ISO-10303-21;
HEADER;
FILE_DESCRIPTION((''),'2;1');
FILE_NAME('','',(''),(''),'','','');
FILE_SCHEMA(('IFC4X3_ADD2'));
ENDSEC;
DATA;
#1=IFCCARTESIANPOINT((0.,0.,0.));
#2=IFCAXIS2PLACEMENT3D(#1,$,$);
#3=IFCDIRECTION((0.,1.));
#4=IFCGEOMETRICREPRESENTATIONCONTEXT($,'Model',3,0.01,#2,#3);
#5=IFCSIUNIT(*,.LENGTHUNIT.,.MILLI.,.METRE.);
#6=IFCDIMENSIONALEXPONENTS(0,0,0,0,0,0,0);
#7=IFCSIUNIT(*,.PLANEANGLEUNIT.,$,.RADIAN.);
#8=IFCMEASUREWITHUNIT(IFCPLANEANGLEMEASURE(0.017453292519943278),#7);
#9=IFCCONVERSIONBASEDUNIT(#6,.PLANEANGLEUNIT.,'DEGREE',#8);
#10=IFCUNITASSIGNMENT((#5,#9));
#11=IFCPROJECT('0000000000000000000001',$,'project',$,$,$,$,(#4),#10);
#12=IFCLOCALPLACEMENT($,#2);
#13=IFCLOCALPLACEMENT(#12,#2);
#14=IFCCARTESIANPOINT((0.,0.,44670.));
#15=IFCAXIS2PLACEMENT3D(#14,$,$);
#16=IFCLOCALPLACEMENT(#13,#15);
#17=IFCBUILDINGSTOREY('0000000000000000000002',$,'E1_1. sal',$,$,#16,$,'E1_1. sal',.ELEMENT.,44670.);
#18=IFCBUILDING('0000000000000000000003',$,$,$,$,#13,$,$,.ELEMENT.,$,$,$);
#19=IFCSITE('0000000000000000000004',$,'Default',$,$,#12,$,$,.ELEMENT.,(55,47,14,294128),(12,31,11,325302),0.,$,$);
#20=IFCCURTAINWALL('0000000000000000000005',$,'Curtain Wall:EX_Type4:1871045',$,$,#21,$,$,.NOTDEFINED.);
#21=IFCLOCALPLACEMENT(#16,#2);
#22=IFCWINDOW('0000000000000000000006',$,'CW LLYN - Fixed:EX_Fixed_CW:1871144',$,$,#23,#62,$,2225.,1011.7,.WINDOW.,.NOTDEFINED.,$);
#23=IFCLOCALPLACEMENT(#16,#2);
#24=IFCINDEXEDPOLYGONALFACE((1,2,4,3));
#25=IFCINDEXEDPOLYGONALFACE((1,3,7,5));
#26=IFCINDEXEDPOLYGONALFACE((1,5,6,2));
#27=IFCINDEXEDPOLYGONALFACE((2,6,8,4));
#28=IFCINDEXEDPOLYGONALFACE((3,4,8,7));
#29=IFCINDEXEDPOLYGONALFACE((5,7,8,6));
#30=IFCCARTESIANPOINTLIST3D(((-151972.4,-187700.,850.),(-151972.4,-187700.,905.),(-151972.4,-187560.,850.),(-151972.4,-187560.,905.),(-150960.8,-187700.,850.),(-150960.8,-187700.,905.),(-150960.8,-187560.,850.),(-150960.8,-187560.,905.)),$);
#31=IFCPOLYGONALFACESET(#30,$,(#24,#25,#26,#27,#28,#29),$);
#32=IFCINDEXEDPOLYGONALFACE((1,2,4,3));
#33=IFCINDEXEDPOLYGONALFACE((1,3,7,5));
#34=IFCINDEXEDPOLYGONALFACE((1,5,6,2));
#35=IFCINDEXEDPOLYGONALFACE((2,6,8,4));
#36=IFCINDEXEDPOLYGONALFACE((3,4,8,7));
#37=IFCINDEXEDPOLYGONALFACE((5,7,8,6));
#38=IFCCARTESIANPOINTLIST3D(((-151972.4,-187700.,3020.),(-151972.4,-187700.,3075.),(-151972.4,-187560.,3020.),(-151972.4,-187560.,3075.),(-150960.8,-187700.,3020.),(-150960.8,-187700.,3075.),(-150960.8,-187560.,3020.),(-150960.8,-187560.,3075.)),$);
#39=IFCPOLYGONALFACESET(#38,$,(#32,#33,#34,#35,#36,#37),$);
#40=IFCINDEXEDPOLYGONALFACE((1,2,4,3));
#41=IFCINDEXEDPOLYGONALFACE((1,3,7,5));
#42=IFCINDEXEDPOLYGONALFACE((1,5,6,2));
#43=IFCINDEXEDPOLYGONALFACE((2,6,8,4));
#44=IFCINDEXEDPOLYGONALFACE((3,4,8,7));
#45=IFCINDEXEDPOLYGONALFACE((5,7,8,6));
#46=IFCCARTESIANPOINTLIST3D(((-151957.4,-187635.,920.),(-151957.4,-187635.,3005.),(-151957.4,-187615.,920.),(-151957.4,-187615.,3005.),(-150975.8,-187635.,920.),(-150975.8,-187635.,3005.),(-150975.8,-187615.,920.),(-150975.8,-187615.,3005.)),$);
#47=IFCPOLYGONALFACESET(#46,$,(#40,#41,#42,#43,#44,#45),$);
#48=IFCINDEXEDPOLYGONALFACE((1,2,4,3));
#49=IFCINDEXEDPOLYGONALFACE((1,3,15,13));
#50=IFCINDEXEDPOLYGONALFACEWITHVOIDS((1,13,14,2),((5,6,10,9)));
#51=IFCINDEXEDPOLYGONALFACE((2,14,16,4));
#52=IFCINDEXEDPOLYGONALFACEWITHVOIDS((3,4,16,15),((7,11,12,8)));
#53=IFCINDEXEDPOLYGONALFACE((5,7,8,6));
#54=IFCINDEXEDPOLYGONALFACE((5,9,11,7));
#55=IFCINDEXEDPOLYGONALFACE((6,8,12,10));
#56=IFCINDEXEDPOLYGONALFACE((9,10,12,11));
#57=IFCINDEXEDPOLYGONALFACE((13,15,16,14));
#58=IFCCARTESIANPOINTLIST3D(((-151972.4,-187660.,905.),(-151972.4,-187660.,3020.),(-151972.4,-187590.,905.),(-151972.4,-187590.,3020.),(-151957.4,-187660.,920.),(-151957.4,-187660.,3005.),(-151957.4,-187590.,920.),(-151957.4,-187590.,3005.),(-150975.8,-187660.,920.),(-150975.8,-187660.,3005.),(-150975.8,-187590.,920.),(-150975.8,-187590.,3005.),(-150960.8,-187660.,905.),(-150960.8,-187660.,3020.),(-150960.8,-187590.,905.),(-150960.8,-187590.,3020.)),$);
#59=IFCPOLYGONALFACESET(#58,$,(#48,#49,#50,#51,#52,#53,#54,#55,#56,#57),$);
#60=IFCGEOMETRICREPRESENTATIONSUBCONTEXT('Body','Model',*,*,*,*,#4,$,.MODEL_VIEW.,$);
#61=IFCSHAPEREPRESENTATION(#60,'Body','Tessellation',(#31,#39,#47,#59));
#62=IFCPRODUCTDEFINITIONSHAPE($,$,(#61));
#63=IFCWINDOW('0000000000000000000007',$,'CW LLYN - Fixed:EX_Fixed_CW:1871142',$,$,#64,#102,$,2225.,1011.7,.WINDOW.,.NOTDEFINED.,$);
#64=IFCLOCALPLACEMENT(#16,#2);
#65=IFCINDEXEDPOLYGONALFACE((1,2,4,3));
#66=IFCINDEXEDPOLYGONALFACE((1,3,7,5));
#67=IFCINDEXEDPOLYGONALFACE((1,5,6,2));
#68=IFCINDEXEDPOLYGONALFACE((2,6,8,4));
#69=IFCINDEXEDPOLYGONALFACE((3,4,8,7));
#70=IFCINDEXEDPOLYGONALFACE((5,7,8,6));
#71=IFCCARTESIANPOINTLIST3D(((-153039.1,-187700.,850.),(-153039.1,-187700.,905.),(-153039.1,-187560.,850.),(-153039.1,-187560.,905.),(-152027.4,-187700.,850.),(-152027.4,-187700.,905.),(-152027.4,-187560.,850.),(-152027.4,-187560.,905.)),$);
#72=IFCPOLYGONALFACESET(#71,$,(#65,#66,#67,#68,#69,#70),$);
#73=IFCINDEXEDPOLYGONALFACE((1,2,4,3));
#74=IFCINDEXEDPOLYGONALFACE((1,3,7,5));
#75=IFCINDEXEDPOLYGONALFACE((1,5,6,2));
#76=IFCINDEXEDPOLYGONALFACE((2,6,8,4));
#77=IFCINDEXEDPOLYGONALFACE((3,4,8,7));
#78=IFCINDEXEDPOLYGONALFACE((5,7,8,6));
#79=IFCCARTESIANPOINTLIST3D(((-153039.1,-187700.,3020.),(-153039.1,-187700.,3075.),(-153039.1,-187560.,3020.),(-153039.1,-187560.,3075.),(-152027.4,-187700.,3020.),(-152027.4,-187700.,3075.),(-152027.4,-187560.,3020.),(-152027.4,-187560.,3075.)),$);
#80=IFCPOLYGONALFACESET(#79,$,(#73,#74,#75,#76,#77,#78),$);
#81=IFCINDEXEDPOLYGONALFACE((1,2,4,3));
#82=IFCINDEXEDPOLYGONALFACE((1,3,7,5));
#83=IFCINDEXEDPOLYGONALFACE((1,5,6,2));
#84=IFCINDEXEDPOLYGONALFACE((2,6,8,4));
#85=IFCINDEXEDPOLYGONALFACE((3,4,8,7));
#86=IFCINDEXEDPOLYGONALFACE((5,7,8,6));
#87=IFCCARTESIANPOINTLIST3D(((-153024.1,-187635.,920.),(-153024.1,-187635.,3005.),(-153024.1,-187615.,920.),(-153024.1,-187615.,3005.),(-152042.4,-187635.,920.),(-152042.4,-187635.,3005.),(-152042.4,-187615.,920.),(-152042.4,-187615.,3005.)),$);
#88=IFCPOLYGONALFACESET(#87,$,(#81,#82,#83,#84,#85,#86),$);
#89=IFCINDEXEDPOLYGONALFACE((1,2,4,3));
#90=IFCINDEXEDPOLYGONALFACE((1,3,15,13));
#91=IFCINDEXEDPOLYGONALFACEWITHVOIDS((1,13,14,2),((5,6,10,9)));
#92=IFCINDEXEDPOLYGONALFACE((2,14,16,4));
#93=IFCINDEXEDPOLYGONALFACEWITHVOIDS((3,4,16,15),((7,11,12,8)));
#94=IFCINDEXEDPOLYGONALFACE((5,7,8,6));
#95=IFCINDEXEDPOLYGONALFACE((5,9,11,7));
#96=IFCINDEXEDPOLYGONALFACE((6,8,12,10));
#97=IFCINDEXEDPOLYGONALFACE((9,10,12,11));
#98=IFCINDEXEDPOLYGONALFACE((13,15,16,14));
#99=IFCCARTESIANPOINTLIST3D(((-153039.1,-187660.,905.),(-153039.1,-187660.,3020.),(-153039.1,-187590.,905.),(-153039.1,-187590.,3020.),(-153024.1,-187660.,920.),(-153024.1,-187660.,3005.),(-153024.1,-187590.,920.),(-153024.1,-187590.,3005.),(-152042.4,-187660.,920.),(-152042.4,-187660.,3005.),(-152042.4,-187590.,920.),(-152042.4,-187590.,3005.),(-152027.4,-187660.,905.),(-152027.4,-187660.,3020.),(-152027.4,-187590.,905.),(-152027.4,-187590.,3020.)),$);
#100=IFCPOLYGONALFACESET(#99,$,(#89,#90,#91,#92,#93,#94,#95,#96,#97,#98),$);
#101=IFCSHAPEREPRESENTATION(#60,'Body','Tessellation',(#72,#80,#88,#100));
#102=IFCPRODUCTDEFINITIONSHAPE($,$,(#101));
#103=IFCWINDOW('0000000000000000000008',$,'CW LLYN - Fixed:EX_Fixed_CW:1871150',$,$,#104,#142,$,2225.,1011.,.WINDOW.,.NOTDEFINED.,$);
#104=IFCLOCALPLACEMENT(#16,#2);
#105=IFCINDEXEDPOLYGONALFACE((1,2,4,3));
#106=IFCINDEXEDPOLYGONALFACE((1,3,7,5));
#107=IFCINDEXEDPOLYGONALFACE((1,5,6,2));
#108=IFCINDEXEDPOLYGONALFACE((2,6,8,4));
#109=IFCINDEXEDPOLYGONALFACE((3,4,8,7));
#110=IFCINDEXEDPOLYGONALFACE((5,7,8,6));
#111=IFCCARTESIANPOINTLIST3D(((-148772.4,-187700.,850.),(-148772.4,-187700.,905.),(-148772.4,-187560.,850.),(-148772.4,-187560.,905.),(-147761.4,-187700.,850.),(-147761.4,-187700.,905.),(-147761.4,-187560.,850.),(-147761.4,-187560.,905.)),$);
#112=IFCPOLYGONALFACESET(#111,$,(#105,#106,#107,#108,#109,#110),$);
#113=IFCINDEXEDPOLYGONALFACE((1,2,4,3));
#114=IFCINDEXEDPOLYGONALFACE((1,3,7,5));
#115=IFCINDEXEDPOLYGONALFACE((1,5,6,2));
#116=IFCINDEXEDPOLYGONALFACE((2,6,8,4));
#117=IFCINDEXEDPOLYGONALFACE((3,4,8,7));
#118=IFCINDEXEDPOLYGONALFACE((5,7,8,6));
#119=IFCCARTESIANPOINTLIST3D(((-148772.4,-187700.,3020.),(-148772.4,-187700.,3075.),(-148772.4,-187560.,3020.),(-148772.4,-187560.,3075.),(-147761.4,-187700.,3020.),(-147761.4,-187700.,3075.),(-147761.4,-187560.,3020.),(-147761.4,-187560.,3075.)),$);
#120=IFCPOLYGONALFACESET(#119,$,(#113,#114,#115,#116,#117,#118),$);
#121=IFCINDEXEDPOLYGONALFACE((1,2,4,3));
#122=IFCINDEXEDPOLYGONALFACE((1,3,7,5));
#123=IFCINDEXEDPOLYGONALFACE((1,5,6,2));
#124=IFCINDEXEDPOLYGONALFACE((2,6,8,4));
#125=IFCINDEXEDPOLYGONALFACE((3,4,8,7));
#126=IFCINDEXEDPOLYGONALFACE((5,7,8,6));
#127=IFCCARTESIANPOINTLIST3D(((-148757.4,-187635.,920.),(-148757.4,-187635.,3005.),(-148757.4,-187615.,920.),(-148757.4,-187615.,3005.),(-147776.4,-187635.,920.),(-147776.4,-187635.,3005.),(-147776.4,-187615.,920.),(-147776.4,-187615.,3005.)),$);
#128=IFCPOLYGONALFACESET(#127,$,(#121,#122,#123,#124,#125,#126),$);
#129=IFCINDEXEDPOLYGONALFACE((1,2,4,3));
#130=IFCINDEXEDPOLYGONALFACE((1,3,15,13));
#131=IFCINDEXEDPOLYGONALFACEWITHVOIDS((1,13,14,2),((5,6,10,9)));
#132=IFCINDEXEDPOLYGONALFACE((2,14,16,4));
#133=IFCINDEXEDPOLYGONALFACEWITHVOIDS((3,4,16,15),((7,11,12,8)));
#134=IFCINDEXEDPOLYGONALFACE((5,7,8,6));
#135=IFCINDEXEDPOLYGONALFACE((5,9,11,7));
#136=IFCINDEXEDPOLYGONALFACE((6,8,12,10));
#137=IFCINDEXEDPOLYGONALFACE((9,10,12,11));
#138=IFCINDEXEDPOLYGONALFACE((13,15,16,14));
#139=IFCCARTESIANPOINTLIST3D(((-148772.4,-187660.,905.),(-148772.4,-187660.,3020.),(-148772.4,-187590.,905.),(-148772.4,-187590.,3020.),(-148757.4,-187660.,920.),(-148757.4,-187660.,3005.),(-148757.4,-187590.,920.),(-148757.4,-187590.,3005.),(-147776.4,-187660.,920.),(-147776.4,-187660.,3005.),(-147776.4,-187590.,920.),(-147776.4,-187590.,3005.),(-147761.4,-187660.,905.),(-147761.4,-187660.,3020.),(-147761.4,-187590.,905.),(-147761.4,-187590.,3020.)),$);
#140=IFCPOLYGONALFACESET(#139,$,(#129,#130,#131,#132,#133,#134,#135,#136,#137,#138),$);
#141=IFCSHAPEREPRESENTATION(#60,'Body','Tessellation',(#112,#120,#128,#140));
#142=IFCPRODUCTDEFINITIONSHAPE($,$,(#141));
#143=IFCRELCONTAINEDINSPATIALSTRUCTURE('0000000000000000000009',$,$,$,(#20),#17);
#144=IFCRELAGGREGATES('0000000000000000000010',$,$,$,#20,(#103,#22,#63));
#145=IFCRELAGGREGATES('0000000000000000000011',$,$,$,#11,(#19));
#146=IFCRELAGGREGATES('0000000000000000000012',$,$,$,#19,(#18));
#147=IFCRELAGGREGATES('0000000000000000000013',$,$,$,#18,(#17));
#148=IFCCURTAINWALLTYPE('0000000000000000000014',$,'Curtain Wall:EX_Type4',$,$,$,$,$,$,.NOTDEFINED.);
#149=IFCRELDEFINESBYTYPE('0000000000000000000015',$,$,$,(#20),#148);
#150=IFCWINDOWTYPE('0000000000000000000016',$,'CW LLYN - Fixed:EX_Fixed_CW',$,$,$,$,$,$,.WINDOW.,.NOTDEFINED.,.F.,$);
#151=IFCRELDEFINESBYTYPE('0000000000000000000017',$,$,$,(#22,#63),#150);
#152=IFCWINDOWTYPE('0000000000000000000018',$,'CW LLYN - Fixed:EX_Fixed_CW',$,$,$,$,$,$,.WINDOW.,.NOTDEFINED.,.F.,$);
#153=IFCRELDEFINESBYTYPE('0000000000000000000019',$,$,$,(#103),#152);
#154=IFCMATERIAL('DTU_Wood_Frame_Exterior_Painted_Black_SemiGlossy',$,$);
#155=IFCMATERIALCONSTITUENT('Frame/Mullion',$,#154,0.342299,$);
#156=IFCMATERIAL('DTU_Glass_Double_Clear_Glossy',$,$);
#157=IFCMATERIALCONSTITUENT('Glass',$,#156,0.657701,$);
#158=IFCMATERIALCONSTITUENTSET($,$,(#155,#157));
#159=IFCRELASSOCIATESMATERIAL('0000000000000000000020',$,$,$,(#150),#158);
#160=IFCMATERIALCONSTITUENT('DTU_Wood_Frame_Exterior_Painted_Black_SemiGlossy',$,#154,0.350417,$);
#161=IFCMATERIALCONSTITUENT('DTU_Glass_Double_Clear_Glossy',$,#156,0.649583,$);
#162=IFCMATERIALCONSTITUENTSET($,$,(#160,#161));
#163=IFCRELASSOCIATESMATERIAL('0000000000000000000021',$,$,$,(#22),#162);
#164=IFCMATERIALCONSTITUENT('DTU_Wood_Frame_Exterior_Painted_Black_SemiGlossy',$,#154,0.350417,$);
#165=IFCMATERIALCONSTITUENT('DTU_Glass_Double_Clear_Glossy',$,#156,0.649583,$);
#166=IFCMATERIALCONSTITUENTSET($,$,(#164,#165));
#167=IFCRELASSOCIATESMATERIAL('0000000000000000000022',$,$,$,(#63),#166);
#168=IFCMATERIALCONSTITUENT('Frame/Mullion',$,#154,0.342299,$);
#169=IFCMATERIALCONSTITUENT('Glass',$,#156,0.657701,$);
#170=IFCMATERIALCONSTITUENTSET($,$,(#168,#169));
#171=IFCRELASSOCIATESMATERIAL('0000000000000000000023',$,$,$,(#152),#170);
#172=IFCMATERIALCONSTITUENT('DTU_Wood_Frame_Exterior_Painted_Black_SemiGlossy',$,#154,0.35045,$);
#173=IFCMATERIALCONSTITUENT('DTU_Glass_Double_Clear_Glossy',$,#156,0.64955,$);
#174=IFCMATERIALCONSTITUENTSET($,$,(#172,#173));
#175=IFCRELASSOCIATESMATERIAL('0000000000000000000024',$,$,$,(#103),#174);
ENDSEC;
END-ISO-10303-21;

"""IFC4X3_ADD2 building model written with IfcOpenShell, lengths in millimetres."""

from ifc_helpers import new_model, entity, si_unit, converted_unit, direction, frame, frame_2d, origin, origin_2d_with_axis, place, context, subcontext, project, spatial, polyline, rectangle, outline, extrude, source, transform, mapped, material, constituent, constituent_set, type_object, type_shapes, element, aggregate, save


model = new_model("IFC4X3_ADD2")

# Units and contexts
model_context = context("Model", 3, precision=0.01, world=origin(), true_north=direction((0.0, 1.0)))
body_context = subcontext(model_context, "Body", "Model", "MODEL_VIEW")
ifc_project = project(units=[si_unit("LENGTHUNIT", "METRE", prefix="MILLI"), converted_unit("PLANEANGLEUNIT", "DEGREE", entity("IfcPlaneAngleMeasure", 0.017453292519943278), si_unit("PLANEANGLEUNIT", "RADIAN"), dimensions=[0, 0, 0, 0, 0, 0, 0])], contexts=[model_context])

# Site, building, storey
site_placement = place(None, origin())
site = spatial("IfcSite", under=ifc_project, at=site_placement, Name="Default", CompositionType="ELEMENT", RefLatitude=(55, 47, 14, 294128), RefLongitude=(12, 31, 11, 325302), RefElevation=0.0)
building_placement = place(site_placement, origin())
building = spatial("IfcBuilding", under=site, at=building_placement, CompositionType="ELEMENT")
storey_placement = place(building_placement, frame((0.0, 0.0, 44670.0)))
storey = spatial("IfcBuildingStorey", under=building, at=storey_placement, Name="E1_1. sal", LongName="E1_1. sal", CompositionType="ELEMENT", Elevation=44670.0)

# Curtain wall
curtain_wall_type = type_object("IfcCurtainWallType", Name="Curtain Wall:EX_Type4", PredefinedType="NOTDEFINED")
curtain_wall_placement = place(storey_placement, frame((0.0, 0.0, -44670.0)))
curtain_wall = element("IfcCurtainWall", 1, at=curtain_wall_placement, inside=storey, type_object=curtain_wall_type, Name="Curtain Wall:EX_Type4:1871045", PredefinedType="NOTDEFINED")

# Windows
ifc_material_1 = material(Name="DTU_Wood_Frame_Exterior_Painted_Black_SemiGlossy")
ifc_material_2 = material(Name="DTU_Glass_Double_Clear_Glossy")
ifc_constituent_1 = constituent(ifc_material_1, Name="Frame/Mullion", fraction=0.342299)
ifc_constituent_2 = constituent(ifc_material_2, Name="Glass", fraction=0.657701)
ifc_constituent_set_1 = constituent_set(constituents=[ifc_constituent_1, ifc_constituent_2])
window_type_1 = type_object("IfcWindowType", Name="CW LLYN - Fixed:EX_Fixed_CW", ParameterTakesPrecedence=False, PartitioningType="NOTDEFINED", PredefinedType="WINDOW", material=ifc_constituent_set_1)
shared_shape_1 = source(origin(), body_context, "Body", "SweptSolid", [
    extrude(rectangle(XDim=140.0, YDim=1011.7, at=origin_2d_with_axis()), frame((0.0, -130.0, 0.0), z_axis=(0.0, 0.0, 1.0), x_axis=(0.0, -1.0, 0.0)), (0.0, 0.0, 1.0), 55.0),
    extrude(rectangle(XDim=140.0, YDim=1011.7, at=frame_2d((0.0, 0.0), x_axis=(1.0, 0.0))), frame((0.0, -130.0, 2170.0), z_axis=(0.0, 0.0, 1.0), x_axis=(0.0, -1.0, 0.0)), (0.0, 0.0, 1.0), 55.0),
    extrude(rectangle(XDim=981.7, YDim=20.0, at=frame_2d((0.0, 0.0), x_axis=(1.0, 0.0))), frame((0.0, -125.0, 70.0), z_axis=(0.0, 0.0, 1.0), x_axis=(-1.0, 0.0, 0.0)), (0.0, 0.0, 1.0), 2085.0),
    extrude(outline(polyline([(-1057.5, -505.8), (1057.5, -505.8), (1057.5, 505.8), (-1057.5, 505.8), (-1057.5, -505.8)]), holes=[polyline([(-1042.5, 490.8), (1042.5, 490.8), (1042.5, -490.8), (-1042.5, -490.8), (-1042.5, 490.8)])]), frame((0.0, -90.0, 1112.5), z_axis=(0.0, -1.0, 0.0), x_axis=(0.0, 0.0, 1.0)), (0.0, 0.0, 1.0), 70.0),
])
type_shapes(window_type_1, [shared_shape_1])
ifc_constituent_3 = constituent(ifc_material_1, Name="DTU_Wood_Frame_Exterior_Painted_Black_SemiGlossy", fraction=0.350417)
ifc_constituent_4 = constituent(ifc_material_2, Name="DTU_Glass_Double_Clear_Glossy", fraction=0.649583)
ifc_constituent_set_2 = constituent_set(constituents=[ifc_constituent_3, ifc_constituent_4])
window_1_placement = place(curtain_wall_placement, frame((-151466.6, -187500.0, 45520.0)))
window_1 = element("IfcWindow", 2, at=window_1_placement, type_object=window_type_1, material=ifc_constituent_set_2, Name="CW LLYN - Fixed:EX_Fixed_CW:1871144", OverallHeight=2225.0, OverallWidth=1011.7, PartitioningType="NOTDEFINED", PredefinedType="WINDOW", context=body_context, shape_type="MappedRepresentation", body=[
    mapped(shared_shape_1, transform((0.0, 0.0, 0.0), scale=1.0)),
])
ifc_constituent_5 = constituent(ifc_material_1, Name="DTU_Wood_Frame_Exterior_Painted_Black_SemiGlossy", fraction=0.350417)
ifc_constituent_6 = constituent(ifc_material_2, Name="DTU_Glass_Double_Clear_Glossy", fraction=0.649583)
ifc_constituent_set_3 = constituent_set(constituents=[ifc_constituent_5, ifc_constituent_6])
window_2_placement = place(curtain_wall_placement, frame((-152533.3, -187500.0, 45520.0)))
window_2 = element("IfcWindow", 3, at=window_2_placement, type_object=window_type_1, material=ifc_constituent_set_3, Name="CW LLYN - Fixed:EX_Fixed_CW:1871142", OverallHeight=2225.0, OverallWidth=1011.7, PartitioningType="NOTDEFINED", PredefinedType="WINDOW", context=body_context, shape_type="MappedRepresentation", body=[
    mapped(shared_shape_1, transform((0.0, 0.0, 0.0), scale=1.0)),
])

# Window
ifc_constituent_7 = constituent(ifc_material_1, Name="DTU_Wood_Frame_Exterior_Painted_Black_SemiGlossy", fraction=0.35045)
ifc_constituent_8 = constituent(ifc_material_2, Name="DTU_Glass_Double_Clear_Glossy", fraction=0.64955)
ifc_constituent_set_4 = constituent_set(constituents=[ifc_constituent_7, ifc_constituent_8])
ifc_constituent_9 = constituent(ifc_material_1, Name="Frame/Mullion", fraction=0.342299)
ifc_constituent_10 = constituent(ifc_material_2, Name="Glass", fraction=0.657701)
ifc_constituent_set_5 = constituent_set(constituents=[ifc_constituent_9, ifc_constituent_10])
window_type_2 = type_object("IfcWindowType", Name="CW LLYN - Fixed:EX_Fixed_CW", ParameterTakesPrecedence=False, PartitioningType="NOTDEFINED", PredefinedType="WINDOW", material=ifc_constituent_set_5)
shared_shape_2 = source(origin(), body_context, "Body", "SweptSolid", [
    extrude(rectangle(XDim=140.0, YDim=1011.0, at=origin_2d_with_axis()), frame((0.0, -130.0, 0.0), z_axis=(0.0, 0.0, 1.0), x_axis=(0.0, -1.0, 0.0)), (0.0, 0.0, 1.0), 55.0),
    extrude(rectangle(XDim=140.0, YDim=1011.0, at=frame_2d((0.0, 0.0), x_axis=(1.0, 0.0))), frame((0.0, -130.0, 2170.0), z_axis=(0.0, 0.0, 1.0), x_axis=(0.0, -1.0, 0.0)), (0.0, 0.0, 1.0), 55.0),
    extrude(rectangle(XDim=981.0, YDim=20.0, at=origin_2d_with_axis()), frame((0.0, -125.0, 70.0), z_axis=(0.0, 0.0, 1.0), x_axis=(-1.0, 0.0, 0.0)), (0.0, 0.0, 1.0), 2085.0),
    extrude(outline(polyline([(-1057.5, -505.5), (1057.5, -505.5), (1057.5, 505.5), (-1057.5, 505.5), (-1057.5, -505.5)]), holes=[polyline([(-1042.5, 490.5), (1042.5, 490.5), (1042.5, -490.5), (-1042.5, -490.5), (-1042.5, 490.5)])]), frame((0.0, -90.0, 1112.5), z_axis=(0.0, -1.0, 0.0), x_axis=(0.0, 0.0, 1.0)), (0.0, 0.0, 1.0), 70.0),
])
type_shapes(window_type_2, [shared_shape_2])
window_3_placement = place(curtain_wall_placement, frame((-148266.9, -187500.0, 45520.0)))
window_3 = element("IfcWindow", 4, at=window_3_placement, type_object=window_type_2, material=ifc_constituent_set_4, Name="CW LLYN - Fixed:EX_Fixed_CW:1871150", OverallHeight=2225.0, OverallWidth=1011.0, PartitioningType="NOTDEFINED", PredefinedType="WINDOW", context=body_context, shape_type="MappedRepresentation", body=[
    mapped(shared_shape_2, transform((0.0, 0.0, 0.0), scale=1.0)),
])

aggregate(curtain_wall, [window_3, window_1, window_2])

save(model, "model.ifc")
